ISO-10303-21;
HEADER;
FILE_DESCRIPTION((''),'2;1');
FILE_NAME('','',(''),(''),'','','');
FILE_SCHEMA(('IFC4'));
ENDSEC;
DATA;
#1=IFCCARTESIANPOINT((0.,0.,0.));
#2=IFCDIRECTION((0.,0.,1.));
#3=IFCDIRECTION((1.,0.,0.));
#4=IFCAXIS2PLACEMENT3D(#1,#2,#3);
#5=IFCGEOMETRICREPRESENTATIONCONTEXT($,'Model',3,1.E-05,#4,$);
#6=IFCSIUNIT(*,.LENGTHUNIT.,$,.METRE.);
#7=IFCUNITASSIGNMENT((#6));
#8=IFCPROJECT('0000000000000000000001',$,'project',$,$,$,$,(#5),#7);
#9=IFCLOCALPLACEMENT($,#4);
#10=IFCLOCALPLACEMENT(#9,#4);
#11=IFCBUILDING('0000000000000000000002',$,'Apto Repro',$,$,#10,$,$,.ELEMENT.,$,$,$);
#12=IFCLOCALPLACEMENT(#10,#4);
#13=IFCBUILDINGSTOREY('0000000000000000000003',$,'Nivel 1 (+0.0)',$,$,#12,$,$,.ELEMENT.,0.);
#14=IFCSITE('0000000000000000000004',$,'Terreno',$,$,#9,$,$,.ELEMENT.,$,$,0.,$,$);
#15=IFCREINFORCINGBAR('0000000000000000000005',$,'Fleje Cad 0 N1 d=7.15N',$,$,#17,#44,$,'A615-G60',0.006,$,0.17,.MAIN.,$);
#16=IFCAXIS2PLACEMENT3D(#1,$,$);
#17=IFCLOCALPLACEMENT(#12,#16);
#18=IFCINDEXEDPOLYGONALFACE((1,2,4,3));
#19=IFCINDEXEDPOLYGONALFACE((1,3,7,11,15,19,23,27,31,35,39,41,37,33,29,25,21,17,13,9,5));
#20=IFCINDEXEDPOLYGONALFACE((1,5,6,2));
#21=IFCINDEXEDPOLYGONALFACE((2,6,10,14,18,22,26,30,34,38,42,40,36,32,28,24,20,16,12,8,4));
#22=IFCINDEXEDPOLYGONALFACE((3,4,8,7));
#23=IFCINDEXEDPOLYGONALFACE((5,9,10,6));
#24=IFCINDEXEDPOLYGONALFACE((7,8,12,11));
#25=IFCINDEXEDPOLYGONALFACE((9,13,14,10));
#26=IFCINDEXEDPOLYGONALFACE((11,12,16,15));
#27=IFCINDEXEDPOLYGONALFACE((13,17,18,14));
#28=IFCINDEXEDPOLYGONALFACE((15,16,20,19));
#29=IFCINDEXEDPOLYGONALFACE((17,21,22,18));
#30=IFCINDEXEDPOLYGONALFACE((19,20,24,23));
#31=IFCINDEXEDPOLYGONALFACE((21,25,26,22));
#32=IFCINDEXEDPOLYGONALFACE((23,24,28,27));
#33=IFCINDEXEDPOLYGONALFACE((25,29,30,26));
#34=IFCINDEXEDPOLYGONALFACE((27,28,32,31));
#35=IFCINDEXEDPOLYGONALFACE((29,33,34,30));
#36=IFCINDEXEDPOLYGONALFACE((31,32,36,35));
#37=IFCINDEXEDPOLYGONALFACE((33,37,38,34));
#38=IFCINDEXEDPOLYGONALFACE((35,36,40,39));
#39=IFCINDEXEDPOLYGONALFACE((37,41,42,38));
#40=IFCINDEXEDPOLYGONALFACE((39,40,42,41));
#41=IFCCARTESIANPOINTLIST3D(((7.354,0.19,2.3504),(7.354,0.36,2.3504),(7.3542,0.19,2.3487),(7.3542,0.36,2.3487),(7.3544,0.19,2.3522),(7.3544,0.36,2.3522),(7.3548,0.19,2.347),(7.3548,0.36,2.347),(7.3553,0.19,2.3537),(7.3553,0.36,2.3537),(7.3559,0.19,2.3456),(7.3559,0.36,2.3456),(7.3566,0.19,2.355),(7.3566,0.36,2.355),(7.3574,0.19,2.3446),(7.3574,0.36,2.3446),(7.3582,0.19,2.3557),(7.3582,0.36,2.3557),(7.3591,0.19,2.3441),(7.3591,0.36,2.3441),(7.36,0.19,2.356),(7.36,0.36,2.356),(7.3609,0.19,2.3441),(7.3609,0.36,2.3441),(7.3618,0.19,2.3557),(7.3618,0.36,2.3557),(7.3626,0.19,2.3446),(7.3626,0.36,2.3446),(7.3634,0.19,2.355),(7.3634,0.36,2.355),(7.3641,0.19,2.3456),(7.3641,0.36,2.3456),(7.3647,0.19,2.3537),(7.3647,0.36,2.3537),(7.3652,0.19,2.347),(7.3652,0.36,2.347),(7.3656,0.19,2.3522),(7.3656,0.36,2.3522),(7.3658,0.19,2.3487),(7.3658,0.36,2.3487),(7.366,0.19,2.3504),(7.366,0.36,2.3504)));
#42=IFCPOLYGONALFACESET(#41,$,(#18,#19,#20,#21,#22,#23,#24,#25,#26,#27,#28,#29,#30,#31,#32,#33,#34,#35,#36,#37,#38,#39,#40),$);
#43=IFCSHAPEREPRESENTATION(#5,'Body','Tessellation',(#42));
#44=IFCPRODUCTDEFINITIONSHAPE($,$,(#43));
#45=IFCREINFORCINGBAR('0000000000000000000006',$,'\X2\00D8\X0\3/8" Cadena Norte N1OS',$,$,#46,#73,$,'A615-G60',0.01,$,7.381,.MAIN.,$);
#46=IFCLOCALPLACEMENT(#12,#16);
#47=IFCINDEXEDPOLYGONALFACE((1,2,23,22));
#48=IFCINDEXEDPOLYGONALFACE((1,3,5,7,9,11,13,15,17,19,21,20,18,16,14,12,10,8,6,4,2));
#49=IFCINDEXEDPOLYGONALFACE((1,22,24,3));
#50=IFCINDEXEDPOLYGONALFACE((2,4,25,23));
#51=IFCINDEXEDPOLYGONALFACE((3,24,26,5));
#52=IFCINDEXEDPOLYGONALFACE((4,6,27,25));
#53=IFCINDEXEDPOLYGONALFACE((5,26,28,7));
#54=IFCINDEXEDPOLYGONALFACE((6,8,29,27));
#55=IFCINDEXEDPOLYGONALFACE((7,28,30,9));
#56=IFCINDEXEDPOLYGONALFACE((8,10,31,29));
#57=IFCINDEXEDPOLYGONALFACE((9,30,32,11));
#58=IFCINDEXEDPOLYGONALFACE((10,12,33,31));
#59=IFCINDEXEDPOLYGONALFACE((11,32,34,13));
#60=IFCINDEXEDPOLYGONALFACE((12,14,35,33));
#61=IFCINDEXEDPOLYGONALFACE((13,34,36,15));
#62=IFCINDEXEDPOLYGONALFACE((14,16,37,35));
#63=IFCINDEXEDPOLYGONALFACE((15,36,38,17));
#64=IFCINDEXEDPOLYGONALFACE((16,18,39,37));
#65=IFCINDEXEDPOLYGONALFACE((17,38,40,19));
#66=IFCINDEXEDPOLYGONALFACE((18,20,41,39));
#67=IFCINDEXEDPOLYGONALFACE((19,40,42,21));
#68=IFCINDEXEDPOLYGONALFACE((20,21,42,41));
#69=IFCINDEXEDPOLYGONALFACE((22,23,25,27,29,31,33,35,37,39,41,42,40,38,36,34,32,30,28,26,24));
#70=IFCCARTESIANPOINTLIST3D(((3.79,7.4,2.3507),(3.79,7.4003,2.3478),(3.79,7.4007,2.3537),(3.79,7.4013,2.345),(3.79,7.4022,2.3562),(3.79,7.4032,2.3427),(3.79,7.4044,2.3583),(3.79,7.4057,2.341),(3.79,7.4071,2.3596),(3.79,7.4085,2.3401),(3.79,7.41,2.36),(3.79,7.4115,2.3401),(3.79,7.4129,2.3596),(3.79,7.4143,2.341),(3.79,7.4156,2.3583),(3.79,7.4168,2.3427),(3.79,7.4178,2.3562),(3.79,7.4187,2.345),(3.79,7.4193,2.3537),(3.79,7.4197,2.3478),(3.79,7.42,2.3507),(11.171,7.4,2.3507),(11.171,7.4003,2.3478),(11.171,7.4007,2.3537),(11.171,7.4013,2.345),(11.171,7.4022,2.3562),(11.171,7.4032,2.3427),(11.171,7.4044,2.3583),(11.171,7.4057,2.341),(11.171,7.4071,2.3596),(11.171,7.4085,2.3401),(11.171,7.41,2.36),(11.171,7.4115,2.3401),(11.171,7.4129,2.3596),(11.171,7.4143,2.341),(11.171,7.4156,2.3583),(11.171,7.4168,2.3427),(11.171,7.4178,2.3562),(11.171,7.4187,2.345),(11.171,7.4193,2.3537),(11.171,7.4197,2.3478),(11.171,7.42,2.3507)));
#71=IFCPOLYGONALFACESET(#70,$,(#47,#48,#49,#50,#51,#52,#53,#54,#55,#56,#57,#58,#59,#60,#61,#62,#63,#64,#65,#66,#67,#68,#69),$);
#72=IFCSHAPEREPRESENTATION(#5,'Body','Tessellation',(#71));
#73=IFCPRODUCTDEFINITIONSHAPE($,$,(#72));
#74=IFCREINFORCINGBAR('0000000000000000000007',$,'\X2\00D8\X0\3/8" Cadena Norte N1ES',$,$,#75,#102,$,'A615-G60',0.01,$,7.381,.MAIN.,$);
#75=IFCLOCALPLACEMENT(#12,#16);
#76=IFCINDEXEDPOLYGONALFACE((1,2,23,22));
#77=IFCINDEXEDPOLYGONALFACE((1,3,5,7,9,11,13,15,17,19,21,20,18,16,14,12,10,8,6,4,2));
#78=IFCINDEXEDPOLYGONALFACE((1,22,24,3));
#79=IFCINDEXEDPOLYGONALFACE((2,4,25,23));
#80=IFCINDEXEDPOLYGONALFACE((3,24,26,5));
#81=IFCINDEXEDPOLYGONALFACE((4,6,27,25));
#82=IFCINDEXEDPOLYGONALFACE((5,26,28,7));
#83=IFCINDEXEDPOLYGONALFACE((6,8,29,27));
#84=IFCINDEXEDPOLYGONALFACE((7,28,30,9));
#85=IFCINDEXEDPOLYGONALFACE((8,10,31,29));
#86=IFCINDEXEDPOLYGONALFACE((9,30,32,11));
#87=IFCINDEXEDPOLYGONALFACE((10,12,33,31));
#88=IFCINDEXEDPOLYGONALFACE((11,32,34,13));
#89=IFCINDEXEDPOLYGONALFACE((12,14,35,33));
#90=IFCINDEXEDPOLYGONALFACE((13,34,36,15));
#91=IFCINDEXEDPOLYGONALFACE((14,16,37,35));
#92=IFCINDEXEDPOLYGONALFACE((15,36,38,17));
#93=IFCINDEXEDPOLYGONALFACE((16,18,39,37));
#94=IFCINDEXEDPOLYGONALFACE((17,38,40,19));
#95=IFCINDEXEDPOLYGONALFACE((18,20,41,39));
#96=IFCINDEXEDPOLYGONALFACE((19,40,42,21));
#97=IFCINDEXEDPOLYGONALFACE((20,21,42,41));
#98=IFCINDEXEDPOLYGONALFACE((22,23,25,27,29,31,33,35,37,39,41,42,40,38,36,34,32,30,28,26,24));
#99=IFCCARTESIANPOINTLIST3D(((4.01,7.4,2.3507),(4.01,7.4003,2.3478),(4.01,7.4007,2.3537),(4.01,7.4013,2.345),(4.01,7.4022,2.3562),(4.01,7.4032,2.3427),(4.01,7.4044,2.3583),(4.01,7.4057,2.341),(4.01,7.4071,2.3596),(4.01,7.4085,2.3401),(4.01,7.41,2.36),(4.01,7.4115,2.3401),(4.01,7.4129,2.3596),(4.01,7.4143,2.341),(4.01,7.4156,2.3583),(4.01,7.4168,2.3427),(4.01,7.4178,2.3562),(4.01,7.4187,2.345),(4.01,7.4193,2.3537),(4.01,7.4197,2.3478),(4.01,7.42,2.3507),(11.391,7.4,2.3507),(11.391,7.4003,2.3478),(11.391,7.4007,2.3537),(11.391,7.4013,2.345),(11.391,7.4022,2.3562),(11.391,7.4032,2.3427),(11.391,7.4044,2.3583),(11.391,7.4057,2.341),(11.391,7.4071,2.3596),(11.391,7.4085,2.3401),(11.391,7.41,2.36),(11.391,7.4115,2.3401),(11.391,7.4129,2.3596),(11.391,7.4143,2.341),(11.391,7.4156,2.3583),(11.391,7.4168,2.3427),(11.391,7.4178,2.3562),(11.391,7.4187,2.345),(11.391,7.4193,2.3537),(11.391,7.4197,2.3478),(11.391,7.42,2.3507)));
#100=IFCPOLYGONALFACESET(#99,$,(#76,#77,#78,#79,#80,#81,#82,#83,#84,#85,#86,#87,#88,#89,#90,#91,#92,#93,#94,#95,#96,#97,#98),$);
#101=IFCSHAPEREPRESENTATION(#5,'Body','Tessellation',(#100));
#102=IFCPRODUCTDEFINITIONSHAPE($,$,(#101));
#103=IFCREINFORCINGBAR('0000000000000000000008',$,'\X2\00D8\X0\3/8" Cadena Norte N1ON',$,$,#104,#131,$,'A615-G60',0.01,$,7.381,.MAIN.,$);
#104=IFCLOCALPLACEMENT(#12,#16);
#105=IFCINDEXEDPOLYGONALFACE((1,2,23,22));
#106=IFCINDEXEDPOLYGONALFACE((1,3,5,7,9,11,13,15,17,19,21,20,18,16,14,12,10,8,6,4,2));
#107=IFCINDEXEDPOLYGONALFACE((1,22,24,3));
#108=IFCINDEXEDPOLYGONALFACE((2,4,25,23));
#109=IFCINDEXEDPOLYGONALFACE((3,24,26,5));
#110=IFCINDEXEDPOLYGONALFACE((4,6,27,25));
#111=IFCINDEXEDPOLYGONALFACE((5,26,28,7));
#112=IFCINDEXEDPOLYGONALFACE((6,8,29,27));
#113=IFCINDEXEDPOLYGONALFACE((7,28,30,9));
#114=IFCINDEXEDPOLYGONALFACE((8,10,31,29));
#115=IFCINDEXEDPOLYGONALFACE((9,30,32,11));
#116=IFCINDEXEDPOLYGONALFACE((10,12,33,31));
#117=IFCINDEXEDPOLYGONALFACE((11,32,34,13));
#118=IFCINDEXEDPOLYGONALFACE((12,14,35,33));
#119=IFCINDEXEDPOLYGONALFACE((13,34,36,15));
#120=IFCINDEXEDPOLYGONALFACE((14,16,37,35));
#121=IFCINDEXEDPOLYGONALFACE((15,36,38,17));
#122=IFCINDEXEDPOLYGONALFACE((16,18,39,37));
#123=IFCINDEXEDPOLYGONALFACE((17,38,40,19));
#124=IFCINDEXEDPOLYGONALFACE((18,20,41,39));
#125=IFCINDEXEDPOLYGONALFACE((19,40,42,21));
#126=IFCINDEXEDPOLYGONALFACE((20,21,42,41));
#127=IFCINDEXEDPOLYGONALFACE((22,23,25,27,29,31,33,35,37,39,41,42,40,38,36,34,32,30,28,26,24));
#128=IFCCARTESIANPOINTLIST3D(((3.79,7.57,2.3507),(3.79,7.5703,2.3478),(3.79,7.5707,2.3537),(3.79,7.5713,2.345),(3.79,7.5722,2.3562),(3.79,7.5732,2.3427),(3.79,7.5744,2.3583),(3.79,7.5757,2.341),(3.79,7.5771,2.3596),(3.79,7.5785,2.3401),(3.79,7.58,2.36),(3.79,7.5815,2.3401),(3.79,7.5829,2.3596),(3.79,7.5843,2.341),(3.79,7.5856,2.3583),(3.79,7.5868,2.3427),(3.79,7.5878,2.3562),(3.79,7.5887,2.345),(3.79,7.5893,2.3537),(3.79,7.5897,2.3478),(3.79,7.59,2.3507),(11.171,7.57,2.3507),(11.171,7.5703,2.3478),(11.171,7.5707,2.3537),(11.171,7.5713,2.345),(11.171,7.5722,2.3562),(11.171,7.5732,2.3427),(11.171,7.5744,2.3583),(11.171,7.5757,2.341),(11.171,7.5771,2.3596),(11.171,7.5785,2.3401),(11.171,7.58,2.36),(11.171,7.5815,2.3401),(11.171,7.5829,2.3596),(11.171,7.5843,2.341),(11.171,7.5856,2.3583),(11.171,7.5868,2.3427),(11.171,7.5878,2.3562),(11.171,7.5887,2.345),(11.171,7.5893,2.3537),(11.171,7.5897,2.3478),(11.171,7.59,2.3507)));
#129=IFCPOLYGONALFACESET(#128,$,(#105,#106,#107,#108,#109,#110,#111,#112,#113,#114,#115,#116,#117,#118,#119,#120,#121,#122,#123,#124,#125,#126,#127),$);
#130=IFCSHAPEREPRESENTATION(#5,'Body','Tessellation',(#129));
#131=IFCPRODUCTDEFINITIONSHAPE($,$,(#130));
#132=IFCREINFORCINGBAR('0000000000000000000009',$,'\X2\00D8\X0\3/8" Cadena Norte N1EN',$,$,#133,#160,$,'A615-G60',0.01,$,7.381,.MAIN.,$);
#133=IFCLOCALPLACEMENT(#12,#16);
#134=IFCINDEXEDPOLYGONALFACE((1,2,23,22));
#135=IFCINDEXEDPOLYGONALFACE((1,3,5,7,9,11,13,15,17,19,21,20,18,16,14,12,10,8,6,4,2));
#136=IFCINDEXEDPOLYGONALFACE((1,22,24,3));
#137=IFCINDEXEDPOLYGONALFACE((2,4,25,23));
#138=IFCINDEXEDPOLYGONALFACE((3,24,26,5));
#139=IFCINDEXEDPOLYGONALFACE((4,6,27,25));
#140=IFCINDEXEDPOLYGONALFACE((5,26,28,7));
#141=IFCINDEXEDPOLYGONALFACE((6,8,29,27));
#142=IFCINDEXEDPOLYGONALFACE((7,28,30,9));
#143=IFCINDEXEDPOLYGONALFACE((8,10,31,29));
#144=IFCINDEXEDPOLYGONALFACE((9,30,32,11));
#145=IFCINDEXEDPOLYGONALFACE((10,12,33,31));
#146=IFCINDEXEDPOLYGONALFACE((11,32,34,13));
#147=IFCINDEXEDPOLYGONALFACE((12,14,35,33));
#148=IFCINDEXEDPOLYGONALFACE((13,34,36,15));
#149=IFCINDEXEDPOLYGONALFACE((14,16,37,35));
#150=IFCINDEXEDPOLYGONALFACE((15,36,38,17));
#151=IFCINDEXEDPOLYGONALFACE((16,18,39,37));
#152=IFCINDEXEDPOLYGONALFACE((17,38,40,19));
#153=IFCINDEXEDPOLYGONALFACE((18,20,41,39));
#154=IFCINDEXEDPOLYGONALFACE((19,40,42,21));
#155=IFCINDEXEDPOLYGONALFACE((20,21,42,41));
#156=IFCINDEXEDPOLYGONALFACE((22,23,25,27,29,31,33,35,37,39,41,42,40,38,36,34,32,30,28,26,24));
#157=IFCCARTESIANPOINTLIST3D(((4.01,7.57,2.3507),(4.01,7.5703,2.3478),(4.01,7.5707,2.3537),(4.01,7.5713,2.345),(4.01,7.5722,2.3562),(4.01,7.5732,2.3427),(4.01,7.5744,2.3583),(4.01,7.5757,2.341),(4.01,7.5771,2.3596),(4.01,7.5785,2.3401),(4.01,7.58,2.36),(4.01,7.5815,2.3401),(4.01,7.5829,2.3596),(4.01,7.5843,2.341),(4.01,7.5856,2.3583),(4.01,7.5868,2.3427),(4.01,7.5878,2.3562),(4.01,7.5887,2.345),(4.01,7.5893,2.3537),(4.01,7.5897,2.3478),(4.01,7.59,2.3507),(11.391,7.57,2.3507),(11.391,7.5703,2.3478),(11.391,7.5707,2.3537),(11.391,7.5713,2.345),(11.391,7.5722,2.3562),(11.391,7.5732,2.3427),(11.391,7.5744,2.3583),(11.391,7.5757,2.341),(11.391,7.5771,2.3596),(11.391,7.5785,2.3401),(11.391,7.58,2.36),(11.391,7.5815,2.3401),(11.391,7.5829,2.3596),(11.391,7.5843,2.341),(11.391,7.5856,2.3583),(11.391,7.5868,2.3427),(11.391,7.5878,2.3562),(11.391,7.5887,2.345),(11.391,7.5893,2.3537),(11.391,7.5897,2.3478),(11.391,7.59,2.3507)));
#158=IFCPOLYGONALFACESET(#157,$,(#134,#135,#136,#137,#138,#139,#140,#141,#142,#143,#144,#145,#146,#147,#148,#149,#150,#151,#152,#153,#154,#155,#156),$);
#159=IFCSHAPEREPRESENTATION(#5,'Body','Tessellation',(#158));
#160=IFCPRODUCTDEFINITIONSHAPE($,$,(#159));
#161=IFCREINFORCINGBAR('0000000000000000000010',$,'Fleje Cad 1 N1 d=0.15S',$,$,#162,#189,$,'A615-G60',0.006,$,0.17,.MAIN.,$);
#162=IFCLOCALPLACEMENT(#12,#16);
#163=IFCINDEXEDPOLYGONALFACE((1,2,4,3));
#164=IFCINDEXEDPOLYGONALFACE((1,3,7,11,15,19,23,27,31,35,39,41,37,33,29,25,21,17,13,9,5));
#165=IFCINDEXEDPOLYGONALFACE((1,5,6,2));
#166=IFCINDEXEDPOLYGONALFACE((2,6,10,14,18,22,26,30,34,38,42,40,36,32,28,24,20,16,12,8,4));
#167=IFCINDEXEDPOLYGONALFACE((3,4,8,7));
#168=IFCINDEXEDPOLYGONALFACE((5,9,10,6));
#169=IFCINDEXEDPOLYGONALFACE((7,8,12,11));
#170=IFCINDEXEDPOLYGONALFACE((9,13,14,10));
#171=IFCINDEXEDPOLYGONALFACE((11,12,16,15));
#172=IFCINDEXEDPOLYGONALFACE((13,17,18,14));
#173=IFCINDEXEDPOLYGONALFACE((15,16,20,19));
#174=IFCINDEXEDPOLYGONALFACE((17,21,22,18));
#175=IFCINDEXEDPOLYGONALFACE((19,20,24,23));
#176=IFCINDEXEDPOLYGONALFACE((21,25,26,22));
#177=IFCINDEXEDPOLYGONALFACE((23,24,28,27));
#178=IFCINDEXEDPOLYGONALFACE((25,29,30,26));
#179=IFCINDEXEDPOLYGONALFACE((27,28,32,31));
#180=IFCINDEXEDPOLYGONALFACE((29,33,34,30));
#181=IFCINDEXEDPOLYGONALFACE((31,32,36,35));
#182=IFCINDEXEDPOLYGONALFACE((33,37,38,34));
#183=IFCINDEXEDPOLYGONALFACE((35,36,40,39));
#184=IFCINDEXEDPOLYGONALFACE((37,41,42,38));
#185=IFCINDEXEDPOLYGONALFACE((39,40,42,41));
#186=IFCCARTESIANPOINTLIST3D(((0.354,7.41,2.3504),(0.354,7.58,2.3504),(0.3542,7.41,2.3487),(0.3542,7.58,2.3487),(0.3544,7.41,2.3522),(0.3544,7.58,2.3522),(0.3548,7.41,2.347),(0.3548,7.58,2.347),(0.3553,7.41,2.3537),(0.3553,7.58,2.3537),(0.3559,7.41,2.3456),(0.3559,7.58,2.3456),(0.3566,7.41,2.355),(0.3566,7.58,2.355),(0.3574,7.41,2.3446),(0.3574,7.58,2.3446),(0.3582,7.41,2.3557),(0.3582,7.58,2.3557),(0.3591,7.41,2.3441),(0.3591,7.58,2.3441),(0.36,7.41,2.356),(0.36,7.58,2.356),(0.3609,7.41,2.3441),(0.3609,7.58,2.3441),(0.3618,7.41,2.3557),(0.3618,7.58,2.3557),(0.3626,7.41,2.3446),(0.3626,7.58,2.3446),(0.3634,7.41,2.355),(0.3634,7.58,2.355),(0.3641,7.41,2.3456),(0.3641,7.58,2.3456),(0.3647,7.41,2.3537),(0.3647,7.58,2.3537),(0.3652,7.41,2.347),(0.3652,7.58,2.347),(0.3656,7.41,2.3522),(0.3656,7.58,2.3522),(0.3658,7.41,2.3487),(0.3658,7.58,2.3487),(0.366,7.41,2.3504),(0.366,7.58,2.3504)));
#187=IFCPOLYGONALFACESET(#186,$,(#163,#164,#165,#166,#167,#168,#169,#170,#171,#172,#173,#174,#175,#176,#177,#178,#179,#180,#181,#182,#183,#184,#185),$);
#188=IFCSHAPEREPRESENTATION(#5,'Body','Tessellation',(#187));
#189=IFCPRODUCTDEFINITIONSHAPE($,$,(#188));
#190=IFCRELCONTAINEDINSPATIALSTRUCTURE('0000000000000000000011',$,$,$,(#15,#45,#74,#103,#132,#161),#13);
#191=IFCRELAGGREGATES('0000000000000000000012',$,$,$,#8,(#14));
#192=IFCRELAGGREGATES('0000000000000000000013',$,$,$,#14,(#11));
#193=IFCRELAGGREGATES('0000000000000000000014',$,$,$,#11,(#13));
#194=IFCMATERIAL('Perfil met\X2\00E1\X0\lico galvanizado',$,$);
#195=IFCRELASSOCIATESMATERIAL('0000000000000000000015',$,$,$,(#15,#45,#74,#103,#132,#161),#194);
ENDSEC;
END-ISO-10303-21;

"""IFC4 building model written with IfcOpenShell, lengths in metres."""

from ifc_helpers import new_model, si_unit, frame, origin_with_axes, origin_2d_with_axis, place, context, project, spatial, circle, extrude, material, element, save


model = new_model("IFC4")

# Units and contexts
model_context = context("Model", 3, precision=1e-05, world=origin_with_axes())
ifc_project = project(units=[si_unit("LENGTHUNIT", "METRE")], contexts=[model_context])

# Site, building, storey
site_placement = place(None, origin_with_axes())
site = spatial("IfcSite", under=ifc_project, at=site_placement, Name="Terreno", CompositionType="ELEMENT", RefElevation=0.0)
building_placement = place(site_placement, origin_with_axes())
building = spatial("IfcBuilding", under=site, at=building_placement, Name="Apto Repro", CompositionType="ELEMENT")
storey_placement = place(building_placement, origin_with_axes())
storey = spatial("IfcBuildingStorey", under=building, at=storey_placement, Name="Nivel 1 (+0.0)", CompositionType="ELEMENT", Elevation=0.0)

# Reinforcing bars
ifc_material = material(Name="Perfil metálico galvanizado")
reinforcing_bar_1_placement = place(storey_placement, origin_with_axes())
element("IfcReinforcingBar", 1, at=reinforcing_bar_1_placement, inside=storey, material=ifc_material, Name="Fleje Cad 0 N1 d=7.15N", SteelGrade="A615-G60", BarLength=0.17, NominalDiameter=0.006, PredefinedType="MAIN", context=model_context, shape_type="SweptSolid", body=[
    extrude(circle(Radius=0.006, at=origin_2d_with_axis()), frame((7.36, 0.19, 2.35), z_axis=(0.0, 1.0, 0.0), x_axis=(0.0, 0.0, 1.0)), (0.0, 0.0, 1.0), 0.17),
])
reinforcing_bar_2_placement = place(storey_placement, origin_with_axes())
element("IfcReinforcingBar", 2, at=reinforcing_bar_2_placement, inside=storey, material=ifc_material, Name="Ø3/8\" Cadena Norte N1OS", SteelGrade="A615-G60", BarLength=7.381, NominalDiameter=0.01, PredefinedType="MAIN", context=model_context, shape_type="SweptSolid", body=[
    extrude(circle(Radius=0.01, at=origin_2d_with_axis()), frame((3.79, 7.41, 2.35), z_axis=(1.0, 0.0, 0.0), x_axis=(0.0, 0.0, 1.0)), (0.0, 0.0, 1.0), 7.381),
])
reinforcing_bar_3_placement = place(storey_placement, origin_with_axes())
element("IfcReinforcingBar", 3, at=reinforcing_bar_3_placement, inside=storey, material=ifc_material, Name="Ø3/8\" Cadena Norte N1ES", SteelGrade="A615-G60", BarLength=7.381, NominalDiameter=0.01, PredefinedType="MAIN", context=model_context, shape_type="SweptSolid", body=[
    extrude(circle(Radius=0.01, at=origin_2d_with_axis()), frame((4.01, 7.41, 2.35), z_axis=(1.0, 0.0, 0.0), x_axis=(0.0, 0.0, 1.0)), (0.0, 0.0, 1.0), 7.381),
])
reinforcing_bar_4_placement = place(storey_placement, origin_with_axes())
element("IfcReinforcingBar", 4, at=reinforcing_bar_4_placement, inside=storey, material=ifc_material, Name="Ø3/8\" Cadena Norte N1ON", SteelGrade="A615-G60", BarLength=7.381, NominalDiameter=0.01, PredefinedType="MAIN", context=model_context, shape_type="SweptSolid", body=[
    extrude(circle(Radius=0.01, at=origin_2d_with_axis()), frame((3.79, 7.58, 2.35), z_axis=(1.0, 0.0, 0.0), x_axis=(0.0, 0.0, 1.0)), (0.0, 0.0, 1.0), 7.381),
])
reinforcing_bar_5_placement = place(storey_placement, origin_with_axes())
element("IfcReinforcingBar", 5, at=reinforcing_bar_5_placement, inside=storey, material=ifc_material, Name="Ø3/8\" Cadena Norte N1EN", SteelGrade="A615-G60", BarLength=7.381, NominalDiameter=0.01, PredefinedType="MAIN", context=model_context, shape_type="SweptSolid", body=[
    extrude(circle(Radius=0.01, at=origin_2d_with_axis()), frame((4.01, 7.58, 2.35), z_axis=(1.0, 0.0, 0.0), x_axis=(0.0, 0.0, 1.0)), (0.0, 0.0, 1.0), 7.381),
])
reinforcing_bar_6_placement = place(storey_placement, origin_with_axes())
element("IfcReinforcingBar", 6, at=reinforcing_bar_6_placement, inside=storey, material=ifc_material, Name="Fleje Cad 1 N1 d=0.15S", SteelGrade="A615-G60", BarLength=0.17, NominalDiameter=0.006, PredefinedType="MAIN", context=model_context, shape_type="SweptSolid", body=[
    extrude(circle(Radius=0.006, at=origin_2d_with_axis()), frame((0.36, 7.41, 2.35), z_axis=(0.0, 1.0, 0.0), x_axis=(0.0, 0.0, 1.0)), (0.0, 0.0, 1.0), 0.17),
])

save(model, "model.ifc")
